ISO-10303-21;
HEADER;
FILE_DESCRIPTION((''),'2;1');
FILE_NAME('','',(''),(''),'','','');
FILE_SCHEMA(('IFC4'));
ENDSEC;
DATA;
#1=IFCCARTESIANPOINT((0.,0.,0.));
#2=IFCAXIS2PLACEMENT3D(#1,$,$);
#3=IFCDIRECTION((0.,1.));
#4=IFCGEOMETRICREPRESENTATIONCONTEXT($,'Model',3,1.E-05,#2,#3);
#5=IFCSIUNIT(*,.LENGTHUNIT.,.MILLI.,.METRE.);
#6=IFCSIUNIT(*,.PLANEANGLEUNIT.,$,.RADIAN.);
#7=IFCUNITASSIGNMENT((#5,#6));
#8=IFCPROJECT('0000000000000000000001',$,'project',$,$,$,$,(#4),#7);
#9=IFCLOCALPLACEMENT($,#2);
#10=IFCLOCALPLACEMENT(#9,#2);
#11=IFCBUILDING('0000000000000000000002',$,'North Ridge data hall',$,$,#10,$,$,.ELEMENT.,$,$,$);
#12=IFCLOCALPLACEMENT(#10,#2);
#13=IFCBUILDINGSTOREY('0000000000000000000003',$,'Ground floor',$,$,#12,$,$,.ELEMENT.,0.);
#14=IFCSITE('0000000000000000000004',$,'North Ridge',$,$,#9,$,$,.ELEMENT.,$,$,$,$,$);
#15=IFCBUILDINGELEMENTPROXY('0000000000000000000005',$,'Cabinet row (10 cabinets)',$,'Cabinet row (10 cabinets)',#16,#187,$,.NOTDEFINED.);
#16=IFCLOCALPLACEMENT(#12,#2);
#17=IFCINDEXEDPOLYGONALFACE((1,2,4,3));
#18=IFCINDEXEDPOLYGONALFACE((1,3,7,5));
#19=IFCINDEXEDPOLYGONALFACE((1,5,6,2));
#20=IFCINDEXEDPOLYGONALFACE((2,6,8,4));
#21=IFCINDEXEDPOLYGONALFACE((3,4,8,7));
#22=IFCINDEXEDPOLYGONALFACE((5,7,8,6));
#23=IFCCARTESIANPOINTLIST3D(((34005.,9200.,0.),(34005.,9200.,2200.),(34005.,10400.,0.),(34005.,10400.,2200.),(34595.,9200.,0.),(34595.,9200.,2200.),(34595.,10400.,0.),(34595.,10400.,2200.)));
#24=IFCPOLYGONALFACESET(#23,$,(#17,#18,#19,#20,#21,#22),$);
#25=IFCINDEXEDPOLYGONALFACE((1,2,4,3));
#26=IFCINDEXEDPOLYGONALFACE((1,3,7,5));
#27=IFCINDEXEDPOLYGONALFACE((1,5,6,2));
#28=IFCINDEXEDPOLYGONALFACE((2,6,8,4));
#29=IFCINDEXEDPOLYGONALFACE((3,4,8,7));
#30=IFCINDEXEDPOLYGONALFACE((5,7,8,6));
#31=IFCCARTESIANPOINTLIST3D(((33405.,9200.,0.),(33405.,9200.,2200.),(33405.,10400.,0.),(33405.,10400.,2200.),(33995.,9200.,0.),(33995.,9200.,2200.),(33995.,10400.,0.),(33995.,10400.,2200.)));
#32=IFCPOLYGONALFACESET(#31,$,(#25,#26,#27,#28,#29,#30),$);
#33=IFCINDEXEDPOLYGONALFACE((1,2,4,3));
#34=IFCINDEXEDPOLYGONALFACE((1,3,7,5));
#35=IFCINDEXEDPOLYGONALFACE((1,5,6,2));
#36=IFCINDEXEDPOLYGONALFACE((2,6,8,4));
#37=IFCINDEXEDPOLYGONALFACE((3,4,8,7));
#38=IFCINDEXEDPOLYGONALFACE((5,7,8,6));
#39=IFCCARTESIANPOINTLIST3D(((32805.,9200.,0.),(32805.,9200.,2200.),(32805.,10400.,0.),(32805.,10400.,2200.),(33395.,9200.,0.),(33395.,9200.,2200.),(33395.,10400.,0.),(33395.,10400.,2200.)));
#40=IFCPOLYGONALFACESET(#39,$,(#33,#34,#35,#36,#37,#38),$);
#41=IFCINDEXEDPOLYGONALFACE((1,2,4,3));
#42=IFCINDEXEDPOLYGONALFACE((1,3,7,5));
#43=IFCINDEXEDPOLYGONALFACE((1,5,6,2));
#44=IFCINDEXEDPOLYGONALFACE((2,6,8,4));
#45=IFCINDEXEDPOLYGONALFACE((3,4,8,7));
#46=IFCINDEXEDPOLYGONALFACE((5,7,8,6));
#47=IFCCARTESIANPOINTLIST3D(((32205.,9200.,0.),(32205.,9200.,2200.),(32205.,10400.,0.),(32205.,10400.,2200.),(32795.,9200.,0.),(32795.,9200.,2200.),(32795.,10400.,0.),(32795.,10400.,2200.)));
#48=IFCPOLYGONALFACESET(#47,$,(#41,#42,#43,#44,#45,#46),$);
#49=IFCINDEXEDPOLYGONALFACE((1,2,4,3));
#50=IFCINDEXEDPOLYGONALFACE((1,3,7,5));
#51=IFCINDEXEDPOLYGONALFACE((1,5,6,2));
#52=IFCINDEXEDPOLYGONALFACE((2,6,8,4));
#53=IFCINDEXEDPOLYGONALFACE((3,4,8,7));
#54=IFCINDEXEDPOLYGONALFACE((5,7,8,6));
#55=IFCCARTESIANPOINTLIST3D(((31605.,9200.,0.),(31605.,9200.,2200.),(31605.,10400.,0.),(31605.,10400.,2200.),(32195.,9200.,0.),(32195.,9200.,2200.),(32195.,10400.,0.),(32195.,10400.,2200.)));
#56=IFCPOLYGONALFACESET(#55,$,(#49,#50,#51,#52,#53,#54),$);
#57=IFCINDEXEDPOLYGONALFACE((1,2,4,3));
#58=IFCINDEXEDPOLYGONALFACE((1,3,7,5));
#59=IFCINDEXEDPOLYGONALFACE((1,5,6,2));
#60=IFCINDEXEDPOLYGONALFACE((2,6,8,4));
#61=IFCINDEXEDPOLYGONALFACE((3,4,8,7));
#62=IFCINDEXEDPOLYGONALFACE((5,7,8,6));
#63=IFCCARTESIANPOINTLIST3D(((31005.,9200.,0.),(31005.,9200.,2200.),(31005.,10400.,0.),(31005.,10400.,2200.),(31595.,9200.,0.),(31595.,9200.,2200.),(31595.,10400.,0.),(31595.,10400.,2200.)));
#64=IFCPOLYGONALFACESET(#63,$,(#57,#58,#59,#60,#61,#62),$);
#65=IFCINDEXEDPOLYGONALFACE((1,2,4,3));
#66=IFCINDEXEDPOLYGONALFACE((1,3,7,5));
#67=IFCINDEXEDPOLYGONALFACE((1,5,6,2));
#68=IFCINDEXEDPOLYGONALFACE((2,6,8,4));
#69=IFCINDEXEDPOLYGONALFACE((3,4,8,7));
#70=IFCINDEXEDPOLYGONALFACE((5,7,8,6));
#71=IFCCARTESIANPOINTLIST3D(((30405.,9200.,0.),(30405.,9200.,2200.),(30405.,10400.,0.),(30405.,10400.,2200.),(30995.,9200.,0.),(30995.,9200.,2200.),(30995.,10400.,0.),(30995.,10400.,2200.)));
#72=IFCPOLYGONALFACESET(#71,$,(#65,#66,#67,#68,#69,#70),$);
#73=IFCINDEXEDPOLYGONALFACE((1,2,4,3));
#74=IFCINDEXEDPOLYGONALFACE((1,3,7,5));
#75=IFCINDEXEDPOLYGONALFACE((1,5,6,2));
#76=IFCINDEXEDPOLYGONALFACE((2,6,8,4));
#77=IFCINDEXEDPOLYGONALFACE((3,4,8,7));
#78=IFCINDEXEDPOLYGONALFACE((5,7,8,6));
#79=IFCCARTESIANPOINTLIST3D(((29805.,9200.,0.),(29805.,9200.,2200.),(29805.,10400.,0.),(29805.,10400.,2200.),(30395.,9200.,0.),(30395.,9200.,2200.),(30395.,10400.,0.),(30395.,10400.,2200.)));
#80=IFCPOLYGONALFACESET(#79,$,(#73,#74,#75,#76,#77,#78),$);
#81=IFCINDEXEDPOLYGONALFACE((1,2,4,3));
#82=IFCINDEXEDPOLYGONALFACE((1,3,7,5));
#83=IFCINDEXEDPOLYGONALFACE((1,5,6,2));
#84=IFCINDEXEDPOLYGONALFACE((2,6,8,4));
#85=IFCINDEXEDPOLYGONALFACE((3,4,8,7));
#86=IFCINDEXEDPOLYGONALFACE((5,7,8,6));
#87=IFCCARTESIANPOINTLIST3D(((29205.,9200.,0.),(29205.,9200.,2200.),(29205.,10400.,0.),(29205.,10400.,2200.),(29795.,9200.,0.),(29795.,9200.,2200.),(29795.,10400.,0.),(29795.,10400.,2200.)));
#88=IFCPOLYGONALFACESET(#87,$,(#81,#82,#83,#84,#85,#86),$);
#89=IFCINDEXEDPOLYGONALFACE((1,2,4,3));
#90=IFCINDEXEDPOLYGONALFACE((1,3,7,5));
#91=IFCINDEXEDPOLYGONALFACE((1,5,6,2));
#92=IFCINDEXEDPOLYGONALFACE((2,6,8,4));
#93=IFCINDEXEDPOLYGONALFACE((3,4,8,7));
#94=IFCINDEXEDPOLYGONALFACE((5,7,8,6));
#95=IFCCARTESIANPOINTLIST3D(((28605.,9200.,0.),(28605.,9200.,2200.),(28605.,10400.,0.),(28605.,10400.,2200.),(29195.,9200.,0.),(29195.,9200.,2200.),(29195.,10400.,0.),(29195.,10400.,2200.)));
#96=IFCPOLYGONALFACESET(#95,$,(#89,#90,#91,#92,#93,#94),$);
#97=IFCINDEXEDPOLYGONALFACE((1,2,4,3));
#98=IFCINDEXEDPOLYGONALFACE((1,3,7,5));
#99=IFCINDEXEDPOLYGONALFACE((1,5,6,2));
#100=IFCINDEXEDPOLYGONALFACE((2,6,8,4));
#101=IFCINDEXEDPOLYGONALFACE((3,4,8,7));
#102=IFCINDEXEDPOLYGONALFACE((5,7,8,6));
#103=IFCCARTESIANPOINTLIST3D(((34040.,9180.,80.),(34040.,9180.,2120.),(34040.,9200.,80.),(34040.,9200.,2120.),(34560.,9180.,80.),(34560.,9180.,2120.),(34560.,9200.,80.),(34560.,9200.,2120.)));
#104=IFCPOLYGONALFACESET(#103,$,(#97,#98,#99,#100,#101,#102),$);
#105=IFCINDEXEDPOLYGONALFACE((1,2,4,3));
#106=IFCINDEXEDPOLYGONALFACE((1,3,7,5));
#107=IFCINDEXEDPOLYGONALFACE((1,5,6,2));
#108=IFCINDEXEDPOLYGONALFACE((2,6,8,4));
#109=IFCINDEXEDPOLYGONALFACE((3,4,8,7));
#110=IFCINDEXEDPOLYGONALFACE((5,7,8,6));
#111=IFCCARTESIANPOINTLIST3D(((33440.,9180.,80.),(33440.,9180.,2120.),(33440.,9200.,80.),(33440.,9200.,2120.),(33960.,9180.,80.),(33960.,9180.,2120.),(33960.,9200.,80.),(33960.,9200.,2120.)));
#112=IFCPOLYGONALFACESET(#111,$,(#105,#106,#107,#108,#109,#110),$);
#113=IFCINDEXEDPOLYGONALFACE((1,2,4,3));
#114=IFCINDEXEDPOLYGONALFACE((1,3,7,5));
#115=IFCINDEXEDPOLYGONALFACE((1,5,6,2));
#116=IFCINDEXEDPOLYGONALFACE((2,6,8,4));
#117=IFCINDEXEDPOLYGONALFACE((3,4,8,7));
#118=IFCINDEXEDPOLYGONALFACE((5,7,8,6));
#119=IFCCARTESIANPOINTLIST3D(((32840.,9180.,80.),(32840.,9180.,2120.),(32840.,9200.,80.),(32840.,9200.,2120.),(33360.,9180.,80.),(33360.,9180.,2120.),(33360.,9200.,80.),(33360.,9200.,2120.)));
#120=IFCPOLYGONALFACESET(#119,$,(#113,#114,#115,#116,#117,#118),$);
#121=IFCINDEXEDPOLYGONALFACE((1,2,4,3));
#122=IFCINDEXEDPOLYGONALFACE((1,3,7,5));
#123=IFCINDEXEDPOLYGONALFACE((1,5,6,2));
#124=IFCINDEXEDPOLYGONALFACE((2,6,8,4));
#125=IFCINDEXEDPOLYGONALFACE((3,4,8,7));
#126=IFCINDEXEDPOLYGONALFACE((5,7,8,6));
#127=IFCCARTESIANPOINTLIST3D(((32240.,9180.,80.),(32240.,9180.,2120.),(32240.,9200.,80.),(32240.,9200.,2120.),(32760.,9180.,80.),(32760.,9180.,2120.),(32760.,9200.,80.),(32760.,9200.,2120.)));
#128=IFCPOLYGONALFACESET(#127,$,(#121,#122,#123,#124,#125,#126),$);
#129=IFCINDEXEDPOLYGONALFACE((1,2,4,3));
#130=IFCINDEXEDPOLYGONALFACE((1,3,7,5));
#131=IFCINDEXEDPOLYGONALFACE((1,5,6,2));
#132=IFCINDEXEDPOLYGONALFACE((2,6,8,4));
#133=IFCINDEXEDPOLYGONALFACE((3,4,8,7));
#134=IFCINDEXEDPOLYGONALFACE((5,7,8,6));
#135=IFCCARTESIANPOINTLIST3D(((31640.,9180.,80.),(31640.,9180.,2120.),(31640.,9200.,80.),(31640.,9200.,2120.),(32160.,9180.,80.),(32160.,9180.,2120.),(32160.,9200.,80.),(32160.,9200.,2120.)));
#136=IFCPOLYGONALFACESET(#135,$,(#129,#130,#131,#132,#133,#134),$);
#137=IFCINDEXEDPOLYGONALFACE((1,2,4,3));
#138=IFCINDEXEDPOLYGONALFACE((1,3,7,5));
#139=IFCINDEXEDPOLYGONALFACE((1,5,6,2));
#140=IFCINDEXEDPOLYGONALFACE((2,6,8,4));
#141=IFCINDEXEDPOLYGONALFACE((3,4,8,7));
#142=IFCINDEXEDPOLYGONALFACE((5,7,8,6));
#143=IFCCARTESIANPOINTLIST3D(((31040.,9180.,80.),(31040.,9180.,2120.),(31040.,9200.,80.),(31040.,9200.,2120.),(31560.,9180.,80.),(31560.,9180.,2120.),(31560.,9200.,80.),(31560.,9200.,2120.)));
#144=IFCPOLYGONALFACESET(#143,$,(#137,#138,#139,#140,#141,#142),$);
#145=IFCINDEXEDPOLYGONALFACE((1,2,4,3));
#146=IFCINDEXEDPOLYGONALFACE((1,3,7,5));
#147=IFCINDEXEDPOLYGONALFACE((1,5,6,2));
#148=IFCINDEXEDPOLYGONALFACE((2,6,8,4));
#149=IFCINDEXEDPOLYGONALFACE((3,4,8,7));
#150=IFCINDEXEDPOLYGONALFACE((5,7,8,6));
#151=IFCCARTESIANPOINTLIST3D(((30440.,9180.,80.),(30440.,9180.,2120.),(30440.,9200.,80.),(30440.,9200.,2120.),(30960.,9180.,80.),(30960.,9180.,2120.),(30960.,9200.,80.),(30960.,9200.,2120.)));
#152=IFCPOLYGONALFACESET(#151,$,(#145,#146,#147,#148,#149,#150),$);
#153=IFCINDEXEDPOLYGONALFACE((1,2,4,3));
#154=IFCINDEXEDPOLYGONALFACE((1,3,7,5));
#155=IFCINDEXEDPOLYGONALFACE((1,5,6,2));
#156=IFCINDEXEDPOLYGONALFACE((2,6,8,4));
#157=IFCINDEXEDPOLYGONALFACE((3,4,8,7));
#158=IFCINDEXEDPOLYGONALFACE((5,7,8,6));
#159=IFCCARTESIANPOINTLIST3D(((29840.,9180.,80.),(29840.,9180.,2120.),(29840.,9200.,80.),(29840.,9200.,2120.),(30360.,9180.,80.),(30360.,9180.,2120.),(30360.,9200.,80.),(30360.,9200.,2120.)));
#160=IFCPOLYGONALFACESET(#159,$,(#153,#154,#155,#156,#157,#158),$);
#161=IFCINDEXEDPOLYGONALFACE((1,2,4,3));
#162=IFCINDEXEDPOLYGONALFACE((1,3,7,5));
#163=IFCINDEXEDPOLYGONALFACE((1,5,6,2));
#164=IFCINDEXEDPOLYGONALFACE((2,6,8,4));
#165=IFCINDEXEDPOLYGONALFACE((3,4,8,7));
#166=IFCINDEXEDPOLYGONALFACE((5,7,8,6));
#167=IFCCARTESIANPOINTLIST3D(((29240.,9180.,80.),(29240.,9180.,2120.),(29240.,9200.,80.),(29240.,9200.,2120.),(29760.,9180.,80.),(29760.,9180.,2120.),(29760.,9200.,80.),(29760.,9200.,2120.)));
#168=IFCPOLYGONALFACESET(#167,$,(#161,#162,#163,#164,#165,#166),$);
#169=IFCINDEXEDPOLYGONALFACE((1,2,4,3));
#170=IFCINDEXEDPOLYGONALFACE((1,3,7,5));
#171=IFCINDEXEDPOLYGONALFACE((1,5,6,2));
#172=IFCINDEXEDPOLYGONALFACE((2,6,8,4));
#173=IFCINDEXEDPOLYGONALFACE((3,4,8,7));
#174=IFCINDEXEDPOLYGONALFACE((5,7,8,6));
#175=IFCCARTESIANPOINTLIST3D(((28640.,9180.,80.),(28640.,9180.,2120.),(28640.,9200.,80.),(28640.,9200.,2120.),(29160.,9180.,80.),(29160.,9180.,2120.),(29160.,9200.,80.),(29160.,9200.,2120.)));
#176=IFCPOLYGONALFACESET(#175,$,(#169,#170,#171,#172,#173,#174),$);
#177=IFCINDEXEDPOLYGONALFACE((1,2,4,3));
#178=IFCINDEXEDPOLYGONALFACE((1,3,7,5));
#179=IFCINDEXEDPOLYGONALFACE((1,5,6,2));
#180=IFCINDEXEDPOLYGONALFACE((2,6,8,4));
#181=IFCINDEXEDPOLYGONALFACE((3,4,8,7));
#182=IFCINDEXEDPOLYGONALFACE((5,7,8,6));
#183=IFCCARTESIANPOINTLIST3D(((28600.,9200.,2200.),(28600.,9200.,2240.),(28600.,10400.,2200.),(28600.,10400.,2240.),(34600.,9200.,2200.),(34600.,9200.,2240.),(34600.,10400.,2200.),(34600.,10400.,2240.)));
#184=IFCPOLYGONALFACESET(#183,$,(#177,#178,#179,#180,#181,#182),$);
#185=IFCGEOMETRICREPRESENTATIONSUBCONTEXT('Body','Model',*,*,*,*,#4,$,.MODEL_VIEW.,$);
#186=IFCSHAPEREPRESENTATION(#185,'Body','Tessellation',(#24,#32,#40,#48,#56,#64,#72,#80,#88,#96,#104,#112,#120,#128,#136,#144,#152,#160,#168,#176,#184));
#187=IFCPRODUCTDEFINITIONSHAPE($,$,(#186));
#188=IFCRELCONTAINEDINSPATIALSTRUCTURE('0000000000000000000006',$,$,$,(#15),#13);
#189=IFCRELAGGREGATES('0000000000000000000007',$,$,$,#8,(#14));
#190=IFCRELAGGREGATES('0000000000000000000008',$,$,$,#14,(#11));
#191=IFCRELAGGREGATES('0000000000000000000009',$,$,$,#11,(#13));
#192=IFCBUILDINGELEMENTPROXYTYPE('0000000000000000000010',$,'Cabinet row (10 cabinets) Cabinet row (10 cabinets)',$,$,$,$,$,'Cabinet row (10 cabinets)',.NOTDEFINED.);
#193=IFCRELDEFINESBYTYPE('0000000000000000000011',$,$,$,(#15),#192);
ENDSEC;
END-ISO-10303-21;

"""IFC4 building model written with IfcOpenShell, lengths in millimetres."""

from ifc_helpers import new_model, si_unit, direction, frame, origin, place, context, subcontext, project, spatial, polyline, outline, extrude, source, transform, mapped, type_object, type_shapes, element, save


model = new_model("IFC4")

# Units and contexts
model_context = context("Model", 3, precision=1e-05, world=origin(), true_north=direction((0.0, 1.0)))
body_context = subcontext(model_context, "Body", "Model", "MODEL_VIEW")
ifc_project = project(units=[si_unit("LENGTHUNIT", "METRE", prefix="MILLI"), si_unit("PLANEANGLEUNIT", "RADIAN")], contexts=[model_context])

# Site, building, storey
site_placement = place(None, origin())
site = spatial("IfcSite", under=ifc_project, at=site_placement, Name="North Ridge", CompositionType="ELEMENT")
building_placement = place(site_placement, origin())
building = spatial("IfcBuilding", under=site, at=building_placement, Name="North Ridge data hall", CompositionType="ELEMENT")
storey_placement = place(building_placement, origin())
storey = spatial("IfcBuildingStorey", under=building, at=storey_placement, Name="Ground floor", CompositionType="ELEMENT", Elevation=0.0)

# Building element proxy
building_element_proxy_type_1 = type_object("IfcBuildingElementProxyType", Name="Cabinet row (10 cabinets) Cabinet row (10 cabinets)", ElementType="Cabinet row (10 cabinets)", PredefinedType="NOTDEFINED")
shared_shape_1 = source(origin(), body_context, "Body", "SweptSolid", [
    extrude(outline(polyline([(5.0, 0.0), (595.0, 0.0), (595.0, 1200.0), (5.0, 1200.0), (5.0, 0.0)])), origin(), (0.0, 0.0, 1.0), 2200.0),
    extrude(outline(polyline([(605.0, 0.0), (1195.0, 0.0), (1195.0, 1200.0), (605.0, 1200.0), (605.0, 0.0)])), origin(), (0.0, 0.0, 1.0), 2200.0),
    extrude(outline(polyline([(1205.0, 0.0), (1795.0, 0.0), (1795.0, 1200.0), (1205.0, 1200.0), (1205.0, 0.0)])), origin(), (0.0, 0.0, 1.0), 2200.0),
    extrude(outline(polyline([(1805.0, 0.0), (2395.0, 0.0), (2395.0, 1200.0), (1805.0, 1200.0), (1805.0, 0.0)])), origin(), (0.0, 0.0, 1.0), 2200.0),
    extrude(outline(polyline([(2405.0, 0.0), (2995.0, 0.0), (2995.0, 1200.0), (2405.0, 1200.0), (2405.0, 0.0)])), origin(), (0.0, 0.0, 1.0), 2200.0),
    extrude(outline(polyline([(3005.0, 0.0), (3595.0, 0.0), (3595.0, 1200.0), (3005.0, 1200.0), (3005.0, 0.0)])), origin(), (0.0, 0.0, 1.0), 2200.0),
    extrude(outline(polyline([(3605.0, 0.0), (4195.0, 0.0), (4195.0, 1200.0), (3605.0, 1200.0), (3605.0, 0.0)])), origin(), (0.0, 0.0, 1.0), 2200.0),
    extrude(outline(polyline([(4205.0, 0.0), (4795.0, 0.0), (4795.0, 1200.0), (4205.0, 1200.0), (4205.0, 0.0)])), origin(), (0.0, 0.0, 1.0), 2200.0),
    extrude(outline(polyline([(4805.0, 0.0), (5395.0, 0.0), (5395.0, 1200.0), (4805.0, 1200.0), (4805.0, 0.0)])), origin(), (0.0, 0.0, 1.0), 2200.0),
    extrude(outline(polyline([(5405.0, 0.0), (5995.0, 0.0), (5995.0, 1200.0), (5405.0, 1200.0), (5405.0, 0.0)])), origin(), (0.0, 0.0, 1.0), 2200.0),
    extrude(outline(polyline([(40.0, 1200.0), (560.0, 1200.0), (560.0, 1220.0), (40.0, 1220.0), (40.0, 1200.0)])), frame((0.0, 0.0, 80.0)), (0.0, 0.0, 1.0), 2040.0),
    extrude(outline(polyline([(640.0, 1200.0), (1160.0, 1200.0), (1160.0, 1220.0), (640.0, 1220.0), (640.0, 1200.0)])), frame((0.0, 0.0, 80.0)), (0.0, 0.0, 1.0), 2040.0),
    extrude(outline(polyline([(1240.0, 1200.0), (1760.0, 1200.0), (1760.0, 1220.0), (1240.0, 1220.0), (1240.0, 1200.0)])), frame((0.0, 0.0, 80.0)), (0.0, 0.0, 1.0), 2040.0),
    extrude(outline(polyline([(1840.0, 1200.0), (2360.0, 1200.0), (2360.0, 1220.0), (1840.0, 1220.0), (1840.0, 1200.0)])), frame((0.0, 0.0, 80.0)), (0.0, 0.0, 1.0), 2040.0),
    extrude(outline(polyline([(2440.0, 1200.0), (2960.0, 1200.0), (2960.0, 1220.0), (2440.0, 1220.0), (2440.0, 1200.0)])), frame((0.0, 0.0, 80.0)), (0.0, 0.0, 1.0), 2040.0),
    extrude(outline(polyline([(3040.0, 1200.0), (3560.0, 1200.0), (3560.0, 1220.0), (3040.0, 1220.0), (3040.0, 1200.0)])), frame((0.0, 0.0, 80.0)), (0.0, 0.0, 1.0), 2040.0),
    extrude(outline(polyline([(3640.0, 1200.0), (4160.0, 1200.0), (4160.0, 1220.0), (3640.0, 1220.0), (3640.0, 1200.0)])), frame((0.0, 0.0, 80.0)), (0.0, 0.0, 1.0), 2040.0),
    extrude(outline(polyline([(4240.0, 1200.0), (4760.0, 1200.0), (4760.0, 1220.0), (4240.0, 1220.0), (4240.0, 1200.0)])), frame((0.0, 0.0, 80.0)), (0.0, 0.0, 1.0), 2040.0),
    extrude(outline(polyline([(4840.0, 1200.0), (5360.0, 1200.0), (5360.0, 1220.0), (4840.0, 1220.0), (4840.0, 1200.0)])), frame((0.0, 0.0, 80.0)), (0.0, 0.0, 1.0), 2040.0),
    extrude(outline(polyline([(5440.0, 1200.0), (5960.0, 1200.0), (5960.0, 1220.0), (5440.0, 1220.0), (5440.0, 1200.0)])), frame((0.0, 0.0, 80.0)), (0.0, 0.0, 1.0), 2040.0),
    extrude(outline(polyline([(0.0, 0.0), (6000.0, 0.0), (6000.0, 1200.0), (0.0, 1200.0), (0.0, 0.0)])), frame((0.0, 0.0, 2200.0)), (0.0, 0.0, 1.0), 40.0),
])
type_shapes(building_element_proxy_type_1, [shared_shape_1])
for number, where, z_axis, x_axis, name in (
    (1, (34600.0, 10400.0, 0.0), (0.0, 0.0, 1.0), (-1.0, 0.0, 0.0), "Cabinet row (10 cabinets)"),
):
    element("IfcBuildingElementProxy", number, at=place(storey_placement, frame(where, z_axis=z_axis, x_axis=x_axis)), inside=storey, type_object=building_element_proxy_type_1, Name=name, ObjectType="Cabinet row (10 cabinets)", PredefinedType="NOTDEFINED", context=body_context, shape_type="MappedRepresentation", body=[
        mapped(shared_shape_1, transform((0.0, 0.0, 0.0))),
    ])

save(model, "model.ifc")
